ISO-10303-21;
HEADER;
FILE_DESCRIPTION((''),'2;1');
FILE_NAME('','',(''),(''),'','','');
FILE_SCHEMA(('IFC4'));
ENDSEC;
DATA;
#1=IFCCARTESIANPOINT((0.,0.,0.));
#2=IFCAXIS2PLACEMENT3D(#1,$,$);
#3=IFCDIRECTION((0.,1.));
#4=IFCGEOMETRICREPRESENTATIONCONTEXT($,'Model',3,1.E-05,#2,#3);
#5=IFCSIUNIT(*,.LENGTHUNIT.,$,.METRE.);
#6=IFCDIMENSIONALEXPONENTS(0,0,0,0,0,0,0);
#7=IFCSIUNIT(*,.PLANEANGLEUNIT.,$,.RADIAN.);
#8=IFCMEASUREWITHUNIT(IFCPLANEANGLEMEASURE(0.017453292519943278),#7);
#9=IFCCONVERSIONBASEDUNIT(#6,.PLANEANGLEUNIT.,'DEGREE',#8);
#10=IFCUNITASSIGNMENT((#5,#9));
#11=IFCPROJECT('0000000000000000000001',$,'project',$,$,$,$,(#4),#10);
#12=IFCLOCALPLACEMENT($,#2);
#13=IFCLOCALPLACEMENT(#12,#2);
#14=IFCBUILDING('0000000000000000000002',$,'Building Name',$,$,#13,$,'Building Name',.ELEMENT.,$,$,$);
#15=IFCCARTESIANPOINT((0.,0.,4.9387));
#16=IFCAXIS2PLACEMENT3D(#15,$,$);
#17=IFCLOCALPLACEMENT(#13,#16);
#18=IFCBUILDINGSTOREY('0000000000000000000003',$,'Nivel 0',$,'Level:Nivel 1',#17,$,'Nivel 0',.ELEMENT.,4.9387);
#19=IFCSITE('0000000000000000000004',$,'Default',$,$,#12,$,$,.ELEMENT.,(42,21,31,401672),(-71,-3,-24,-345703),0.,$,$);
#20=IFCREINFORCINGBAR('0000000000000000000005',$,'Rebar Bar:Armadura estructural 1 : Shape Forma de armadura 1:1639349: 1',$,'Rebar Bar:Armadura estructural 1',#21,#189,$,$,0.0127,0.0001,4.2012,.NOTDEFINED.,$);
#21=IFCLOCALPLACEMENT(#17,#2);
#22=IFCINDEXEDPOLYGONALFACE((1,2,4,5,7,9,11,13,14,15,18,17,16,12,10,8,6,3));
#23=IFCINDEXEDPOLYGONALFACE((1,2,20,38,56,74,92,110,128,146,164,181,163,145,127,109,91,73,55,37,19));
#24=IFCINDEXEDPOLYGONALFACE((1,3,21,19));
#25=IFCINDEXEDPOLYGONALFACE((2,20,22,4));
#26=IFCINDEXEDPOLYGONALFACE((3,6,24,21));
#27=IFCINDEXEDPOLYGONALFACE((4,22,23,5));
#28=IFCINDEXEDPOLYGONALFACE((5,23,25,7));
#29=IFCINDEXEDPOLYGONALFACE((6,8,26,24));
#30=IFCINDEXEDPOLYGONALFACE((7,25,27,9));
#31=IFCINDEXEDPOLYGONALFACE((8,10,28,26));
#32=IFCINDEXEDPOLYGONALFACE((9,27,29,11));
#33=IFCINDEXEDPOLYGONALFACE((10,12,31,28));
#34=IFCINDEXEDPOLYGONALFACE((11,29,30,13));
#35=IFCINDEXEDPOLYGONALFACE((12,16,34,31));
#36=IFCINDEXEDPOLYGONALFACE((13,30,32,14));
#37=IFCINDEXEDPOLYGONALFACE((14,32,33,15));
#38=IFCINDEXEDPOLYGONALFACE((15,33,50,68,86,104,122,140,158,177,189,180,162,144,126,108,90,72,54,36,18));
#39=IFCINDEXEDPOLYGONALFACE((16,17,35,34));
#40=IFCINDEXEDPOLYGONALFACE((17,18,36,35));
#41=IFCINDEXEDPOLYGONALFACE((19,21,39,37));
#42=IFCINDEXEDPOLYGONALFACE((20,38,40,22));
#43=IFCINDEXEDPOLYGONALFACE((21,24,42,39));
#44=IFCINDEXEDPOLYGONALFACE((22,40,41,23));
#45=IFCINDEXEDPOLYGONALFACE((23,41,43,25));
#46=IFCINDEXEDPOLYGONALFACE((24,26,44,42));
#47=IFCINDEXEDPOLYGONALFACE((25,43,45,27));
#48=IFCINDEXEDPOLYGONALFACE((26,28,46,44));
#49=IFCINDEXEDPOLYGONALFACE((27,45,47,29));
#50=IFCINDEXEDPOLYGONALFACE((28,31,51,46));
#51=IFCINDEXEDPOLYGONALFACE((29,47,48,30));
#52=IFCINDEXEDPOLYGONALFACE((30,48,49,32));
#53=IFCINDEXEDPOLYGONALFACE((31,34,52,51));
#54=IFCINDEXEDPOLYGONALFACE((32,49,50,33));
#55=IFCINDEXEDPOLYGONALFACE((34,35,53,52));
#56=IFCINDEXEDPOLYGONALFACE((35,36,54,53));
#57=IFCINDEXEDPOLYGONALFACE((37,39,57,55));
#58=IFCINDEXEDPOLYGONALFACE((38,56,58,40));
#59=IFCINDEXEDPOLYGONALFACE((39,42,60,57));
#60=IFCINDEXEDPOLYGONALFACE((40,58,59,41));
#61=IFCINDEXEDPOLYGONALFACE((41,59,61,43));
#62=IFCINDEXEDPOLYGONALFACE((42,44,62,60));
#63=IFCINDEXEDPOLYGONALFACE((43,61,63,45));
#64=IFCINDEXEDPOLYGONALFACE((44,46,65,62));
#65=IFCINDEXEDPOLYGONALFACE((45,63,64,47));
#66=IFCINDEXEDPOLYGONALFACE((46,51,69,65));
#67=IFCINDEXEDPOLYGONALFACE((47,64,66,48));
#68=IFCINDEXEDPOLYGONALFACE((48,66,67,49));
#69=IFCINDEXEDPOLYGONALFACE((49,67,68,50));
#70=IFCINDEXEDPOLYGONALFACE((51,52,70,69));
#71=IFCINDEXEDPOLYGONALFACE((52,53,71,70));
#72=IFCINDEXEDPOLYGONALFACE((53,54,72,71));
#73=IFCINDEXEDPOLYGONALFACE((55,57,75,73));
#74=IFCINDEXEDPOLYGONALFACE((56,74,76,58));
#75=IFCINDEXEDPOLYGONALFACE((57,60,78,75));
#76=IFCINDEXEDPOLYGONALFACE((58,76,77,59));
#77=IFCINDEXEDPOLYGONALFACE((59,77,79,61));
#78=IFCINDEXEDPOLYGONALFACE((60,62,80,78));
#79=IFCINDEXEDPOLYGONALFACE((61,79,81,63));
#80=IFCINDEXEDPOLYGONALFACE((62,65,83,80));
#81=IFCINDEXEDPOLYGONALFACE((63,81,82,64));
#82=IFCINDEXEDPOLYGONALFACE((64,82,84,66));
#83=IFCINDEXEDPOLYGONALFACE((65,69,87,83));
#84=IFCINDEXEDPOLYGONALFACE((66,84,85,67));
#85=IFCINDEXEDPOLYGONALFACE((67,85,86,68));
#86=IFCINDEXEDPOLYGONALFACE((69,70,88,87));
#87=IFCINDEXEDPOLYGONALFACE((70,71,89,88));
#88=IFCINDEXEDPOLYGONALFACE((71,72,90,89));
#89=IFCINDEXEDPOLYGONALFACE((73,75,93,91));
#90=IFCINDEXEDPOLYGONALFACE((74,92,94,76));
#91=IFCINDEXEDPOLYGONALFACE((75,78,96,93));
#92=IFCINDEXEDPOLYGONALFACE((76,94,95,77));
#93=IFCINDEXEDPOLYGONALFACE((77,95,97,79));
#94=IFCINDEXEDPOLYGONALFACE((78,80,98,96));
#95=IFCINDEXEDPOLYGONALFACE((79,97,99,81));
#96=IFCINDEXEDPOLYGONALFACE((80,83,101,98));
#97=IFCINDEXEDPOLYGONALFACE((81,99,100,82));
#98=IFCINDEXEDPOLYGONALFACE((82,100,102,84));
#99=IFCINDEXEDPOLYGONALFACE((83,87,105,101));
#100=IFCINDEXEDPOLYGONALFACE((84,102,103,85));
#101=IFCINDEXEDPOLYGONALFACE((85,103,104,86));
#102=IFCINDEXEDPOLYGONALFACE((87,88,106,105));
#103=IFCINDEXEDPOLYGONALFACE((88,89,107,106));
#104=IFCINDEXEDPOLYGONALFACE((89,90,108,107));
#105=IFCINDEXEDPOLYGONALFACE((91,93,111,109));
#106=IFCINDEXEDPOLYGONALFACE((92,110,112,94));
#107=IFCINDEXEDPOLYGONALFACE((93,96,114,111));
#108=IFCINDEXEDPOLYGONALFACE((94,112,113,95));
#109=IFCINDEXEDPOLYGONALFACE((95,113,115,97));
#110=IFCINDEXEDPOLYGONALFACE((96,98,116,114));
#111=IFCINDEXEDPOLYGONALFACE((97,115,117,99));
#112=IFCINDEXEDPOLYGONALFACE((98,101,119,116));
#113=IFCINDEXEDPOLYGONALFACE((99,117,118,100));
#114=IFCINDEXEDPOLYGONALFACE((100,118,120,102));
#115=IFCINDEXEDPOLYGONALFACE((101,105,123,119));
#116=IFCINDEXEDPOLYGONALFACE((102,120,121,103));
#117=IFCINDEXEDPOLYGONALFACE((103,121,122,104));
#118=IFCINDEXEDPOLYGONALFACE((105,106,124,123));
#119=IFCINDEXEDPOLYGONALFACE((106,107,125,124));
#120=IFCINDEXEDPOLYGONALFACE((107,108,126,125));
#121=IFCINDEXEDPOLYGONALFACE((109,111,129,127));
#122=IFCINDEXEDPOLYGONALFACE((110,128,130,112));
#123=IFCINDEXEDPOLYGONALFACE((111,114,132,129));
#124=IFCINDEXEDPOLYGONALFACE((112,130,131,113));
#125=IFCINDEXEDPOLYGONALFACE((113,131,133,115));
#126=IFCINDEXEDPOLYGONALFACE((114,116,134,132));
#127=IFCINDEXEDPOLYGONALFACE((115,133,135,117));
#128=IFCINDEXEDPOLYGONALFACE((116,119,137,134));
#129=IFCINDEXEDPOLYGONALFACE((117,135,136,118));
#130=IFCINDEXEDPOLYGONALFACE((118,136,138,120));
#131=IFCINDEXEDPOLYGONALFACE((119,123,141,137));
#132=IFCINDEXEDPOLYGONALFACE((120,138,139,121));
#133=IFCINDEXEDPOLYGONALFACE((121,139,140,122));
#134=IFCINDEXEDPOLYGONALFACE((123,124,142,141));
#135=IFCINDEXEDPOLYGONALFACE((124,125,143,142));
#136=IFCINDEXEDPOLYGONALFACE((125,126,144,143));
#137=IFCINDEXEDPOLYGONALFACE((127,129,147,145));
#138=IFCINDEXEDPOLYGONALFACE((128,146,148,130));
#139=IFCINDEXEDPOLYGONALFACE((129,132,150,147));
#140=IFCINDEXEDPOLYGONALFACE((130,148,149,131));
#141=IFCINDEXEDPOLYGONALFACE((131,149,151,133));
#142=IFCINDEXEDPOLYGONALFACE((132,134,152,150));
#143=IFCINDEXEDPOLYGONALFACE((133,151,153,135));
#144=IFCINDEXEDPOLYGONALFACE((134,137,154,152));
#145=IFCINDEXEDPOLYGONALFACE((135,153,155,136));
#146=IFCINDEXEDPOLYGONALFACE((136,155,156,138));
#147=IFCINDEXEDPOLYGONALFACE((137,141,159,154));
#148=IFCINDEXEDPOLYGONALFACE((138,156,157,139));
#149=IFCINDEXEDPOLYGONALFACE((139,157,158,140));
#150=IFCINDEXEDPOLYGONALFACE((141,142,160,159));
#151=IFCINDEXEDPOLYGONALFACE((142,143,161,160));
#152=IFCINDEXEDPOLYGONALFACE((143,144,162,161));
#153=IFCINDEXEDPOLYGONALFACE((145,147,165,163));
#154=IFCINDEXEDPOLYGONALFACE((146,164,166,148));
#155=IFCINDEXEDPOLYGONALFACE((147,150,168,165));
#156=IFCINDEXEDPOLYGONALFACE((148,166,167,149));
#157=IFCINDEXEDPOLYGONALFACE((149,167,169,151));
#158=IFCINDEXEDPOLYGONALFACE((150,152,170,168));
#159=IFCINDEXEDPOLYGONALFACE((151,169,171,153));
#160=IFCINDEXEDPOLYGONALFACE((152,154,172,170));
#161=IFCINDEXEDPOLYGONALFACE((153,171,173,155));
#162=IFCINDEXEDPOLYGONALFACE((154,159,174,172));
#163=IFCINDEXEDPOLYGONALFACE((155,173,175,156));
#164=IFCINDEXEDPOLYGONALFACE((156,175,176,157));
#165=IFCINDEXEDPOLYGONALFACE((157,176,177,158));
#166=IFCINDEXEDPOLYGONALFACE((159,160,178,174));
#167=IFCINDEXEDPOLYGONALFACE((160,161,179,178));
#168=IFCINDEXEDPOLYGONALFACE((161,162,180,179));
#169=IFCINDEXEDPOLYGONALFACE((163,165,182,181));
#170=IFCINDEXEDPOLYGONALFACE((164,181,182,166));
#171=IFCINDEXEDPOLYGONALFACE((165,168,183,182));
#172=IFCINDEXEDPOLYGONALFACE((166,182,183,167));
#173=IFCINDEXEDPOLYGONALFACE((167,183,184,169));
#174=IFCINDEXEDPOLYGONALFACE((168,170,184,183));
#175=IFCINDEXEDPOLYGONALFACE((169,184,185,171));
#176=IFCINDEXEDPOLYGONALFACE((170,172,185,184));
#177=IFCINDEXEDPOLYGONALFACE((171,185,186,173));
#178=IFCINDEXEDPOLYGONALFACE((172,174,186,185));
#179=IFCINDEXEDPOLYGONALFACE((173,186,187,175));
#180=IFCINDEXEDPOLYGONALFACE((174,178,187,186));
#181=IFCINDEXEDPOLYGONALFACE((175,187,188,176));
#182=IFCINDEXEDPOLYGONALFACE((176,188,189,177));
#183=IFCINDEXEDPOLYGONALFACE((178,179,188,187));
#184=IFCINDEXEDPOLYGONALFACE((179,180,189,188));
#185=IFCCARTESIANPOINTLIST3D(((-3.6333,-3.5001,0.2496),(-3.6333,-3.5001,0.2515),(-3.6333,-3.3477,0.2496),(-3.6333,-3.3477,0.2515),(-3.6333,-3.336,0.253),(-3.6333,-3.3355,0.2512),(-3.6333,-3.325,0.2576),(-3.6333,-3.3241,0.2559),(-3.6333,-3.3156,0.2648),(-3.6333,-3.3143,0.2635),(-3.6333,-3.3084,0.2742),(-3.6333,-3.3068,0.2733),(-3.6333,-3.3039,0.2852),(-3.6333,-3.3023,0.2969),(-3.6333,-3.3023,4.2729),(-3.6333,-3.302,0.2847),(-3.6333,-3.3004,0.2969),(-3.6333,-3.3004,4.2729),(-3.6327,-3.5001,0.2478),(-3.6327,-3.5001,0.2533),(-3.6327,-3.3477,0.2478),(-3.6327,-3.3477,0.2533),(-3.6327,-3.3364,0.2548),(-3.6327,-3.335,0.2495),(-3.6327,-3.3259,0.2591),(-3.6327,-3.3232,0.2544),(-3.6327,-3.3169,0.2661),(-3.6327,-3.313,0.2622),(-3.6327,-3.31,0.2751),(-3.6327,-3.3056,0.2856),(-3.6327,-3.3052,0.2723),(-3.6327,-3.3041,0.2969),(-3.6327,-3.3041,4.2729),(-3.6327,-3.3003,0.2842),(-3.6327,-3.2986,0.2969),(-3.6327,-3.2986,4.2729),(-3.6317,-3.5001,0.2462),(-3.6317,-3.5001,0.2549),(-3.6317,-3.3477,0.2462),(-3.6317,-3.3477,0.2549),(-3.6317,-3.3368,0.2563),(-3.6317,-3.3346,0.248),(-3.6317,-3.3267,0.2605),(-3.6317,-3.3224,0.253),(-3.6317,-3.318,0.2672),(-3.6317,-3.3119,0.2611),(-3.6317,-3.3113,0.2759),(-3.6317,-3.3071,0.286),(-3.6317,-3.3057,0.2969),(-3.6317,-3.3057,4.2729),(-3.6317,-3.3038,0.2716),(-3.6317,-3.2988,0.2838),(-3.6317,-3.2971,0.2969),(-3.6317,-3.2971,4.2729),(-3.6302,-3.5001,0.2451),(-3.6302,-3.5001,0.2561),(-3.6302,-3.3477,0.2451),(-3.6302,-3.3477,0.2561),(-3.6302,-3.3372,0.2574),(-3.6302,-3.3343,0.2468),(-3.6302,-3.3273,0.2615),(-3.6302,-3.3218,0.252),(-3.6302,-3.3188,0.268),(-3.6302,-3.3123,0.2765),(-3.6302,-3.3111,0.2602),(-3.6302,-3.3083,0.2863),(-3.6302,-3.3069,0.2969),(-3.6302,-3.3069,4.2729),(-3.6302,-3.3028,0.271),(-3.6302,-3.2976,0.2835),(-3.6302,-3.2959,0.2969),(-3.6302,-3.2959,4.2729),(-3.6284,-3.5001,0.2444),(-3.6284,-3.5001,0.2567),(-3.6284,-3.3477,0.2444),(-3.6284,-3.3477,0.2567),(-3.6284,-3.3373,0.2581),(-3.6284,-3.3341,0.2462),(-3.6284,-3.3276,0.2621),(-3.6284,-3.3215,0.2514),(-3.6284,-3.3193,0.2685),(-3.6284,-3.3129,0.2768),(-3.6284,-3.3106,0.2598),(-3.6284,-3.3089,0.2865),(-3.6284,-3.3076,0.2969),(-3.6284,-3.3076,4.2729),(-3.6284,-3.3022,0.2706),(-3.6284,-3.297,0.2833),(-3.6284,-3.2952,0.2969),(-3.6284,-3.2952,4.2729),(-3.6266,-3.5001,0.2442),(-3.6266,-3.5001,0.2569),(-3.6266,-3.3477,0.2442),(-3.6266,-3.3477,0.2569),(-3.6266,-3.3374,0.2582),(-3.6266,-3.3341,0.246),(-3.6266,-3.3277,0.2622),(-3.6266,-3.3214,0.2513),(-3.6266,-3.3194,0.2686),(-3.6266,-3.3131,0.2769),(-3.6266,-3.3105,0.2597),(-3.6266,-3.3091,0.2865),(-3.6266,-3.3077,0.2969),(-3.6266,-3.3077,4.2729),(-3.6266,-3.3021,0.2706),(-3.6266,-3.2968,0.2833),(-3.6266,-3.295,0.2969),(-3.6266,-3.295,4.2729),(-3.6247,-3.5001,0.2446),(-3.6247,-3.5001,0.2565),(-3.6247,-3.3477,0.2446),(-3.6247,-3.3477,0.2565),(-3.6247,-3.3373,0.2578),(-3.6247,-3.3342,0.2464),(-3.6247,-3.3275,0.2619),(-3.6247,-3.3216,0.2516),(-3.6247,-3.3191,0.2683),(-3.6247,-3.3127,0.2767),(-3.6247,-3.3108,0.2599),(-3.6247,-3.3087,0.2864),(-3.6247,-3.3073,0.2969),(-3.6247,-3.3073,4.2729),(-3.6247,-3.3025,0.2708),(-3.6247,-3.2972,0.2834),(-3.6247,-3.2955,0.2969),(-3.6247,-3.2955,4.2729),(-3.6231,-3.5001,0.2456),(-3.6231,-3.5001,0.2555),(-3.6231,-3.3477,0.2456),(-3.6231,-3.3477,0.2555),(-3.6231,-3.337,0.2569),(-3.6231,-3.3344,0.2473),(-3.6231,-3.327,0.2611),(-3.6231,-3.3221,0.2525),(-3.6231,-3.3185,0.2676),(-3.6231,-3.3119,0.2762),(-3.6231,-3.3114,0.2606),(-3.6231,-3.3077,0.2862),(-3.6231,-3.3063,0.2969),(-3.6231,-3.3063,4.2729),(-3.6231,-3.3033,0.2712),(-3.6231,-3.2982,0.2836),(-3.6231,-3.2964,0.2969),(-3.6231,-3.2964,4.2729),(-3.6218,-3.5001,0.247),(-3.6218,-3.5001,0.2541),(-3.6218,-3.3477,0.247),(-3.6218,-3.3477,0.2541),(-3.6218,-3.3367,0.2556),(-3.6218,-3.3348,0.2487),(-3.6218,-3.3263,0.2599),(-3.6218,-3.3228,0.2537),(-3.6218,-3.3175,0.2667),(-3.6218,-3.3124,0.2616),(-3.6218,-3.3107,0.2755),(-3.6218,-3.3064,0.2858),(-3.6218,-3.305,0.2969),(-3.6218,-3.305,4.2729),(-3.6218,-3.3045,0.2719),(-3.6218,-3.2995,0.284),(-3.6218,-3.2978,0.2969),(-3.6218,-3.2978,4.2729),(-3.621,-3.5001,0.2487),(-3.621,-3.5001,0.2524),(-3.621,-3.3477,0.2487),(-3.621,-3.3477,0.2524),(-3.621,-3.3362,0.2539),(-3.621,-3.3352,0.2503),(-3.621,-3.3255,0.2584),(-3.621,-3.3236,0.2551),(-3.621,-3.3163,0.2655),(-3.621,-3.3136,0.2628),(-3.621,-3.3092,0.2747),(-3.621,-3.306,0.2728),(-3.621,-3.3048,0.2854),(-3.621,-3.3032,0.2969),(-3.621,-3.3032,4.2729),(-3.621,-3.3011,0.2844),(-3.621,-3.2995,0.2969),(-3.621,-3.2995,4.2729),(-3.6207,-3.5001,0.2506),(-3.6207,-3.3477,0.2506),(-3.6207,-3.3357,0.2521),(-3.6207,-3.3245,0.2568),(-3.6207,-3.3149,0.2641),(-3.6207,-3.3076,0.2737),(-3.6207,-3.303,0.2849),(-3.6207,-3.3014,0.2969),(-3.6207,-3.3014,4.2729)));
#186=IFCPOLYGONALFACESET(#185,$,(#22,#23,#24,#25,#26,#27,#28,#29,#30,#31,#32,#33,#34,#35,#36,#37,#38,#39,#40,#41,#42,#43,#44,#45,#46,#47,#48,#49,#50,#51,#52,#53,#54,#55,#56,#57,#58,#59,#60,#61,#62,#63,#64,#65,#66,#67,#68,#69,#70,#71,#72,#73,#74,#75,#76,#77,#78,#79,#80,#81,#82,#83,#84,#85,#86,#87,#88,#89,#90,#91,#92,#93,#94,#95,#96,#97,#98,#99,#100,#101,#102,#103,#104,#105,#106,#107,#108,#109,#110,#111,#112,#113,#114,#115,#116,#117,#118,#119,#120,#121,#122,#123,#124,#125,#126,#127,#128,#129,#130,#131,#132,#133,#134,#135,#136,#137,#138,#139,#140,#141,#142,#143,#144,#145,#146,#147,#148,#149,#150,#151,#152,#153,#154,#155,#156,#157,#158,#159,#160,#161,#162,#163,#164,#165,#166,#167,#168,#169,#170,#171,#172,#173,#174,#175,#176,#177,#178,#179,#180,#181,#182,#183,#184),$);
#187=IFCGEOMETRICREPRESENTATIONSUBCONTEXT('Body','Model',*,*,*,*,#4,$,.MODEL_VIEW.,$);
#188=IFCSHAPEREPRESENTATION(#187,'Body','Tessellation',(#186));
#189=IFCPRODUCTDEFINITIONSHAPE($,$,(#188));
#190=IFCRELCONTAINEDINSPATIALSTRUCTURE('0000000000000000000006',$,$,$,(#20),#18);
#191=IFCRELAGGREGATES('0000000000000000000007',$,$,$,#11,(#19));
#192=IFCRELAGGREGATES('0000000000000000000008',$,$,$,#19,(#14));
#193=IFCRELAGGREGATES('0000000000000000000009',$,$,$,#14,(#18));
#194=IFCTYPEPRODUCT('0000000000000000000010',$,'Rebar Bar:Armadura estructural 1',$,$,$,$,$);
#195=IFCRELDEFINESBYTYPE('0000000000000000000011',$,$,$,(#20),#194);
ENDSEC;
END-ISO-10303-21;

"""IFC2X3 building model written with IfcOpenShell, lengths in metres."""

from ifc_helpers import new_model, entity, si_unit, converted_unit, direction, frame, origin, place, context, subcontext, project, spatial, type_object, element, save


model = new_model("IFC2X3")

# Units and contexts
model_context = context("Model", 3, precision=1e-05, world=origin(), true_north=direction((0.0, 1.0)))
body_context = subcontext(model_context, "Body", "Model", "MODEL_VIEW")
ifc_project = project(units=[si_unit("LENGTHUNIT", "METRE"), converted_unit("PLANEANGLEUNIT", "DEGREE", entity("IfcPlaneAngleMeasure", 0.017453292519943278), si_unit("PLANEANGLEUNIT", "RADIAN"), dimensions=[0, 0, 0, 0, 0, 0, 0])], contexts=[model_context])

# Site, building, storey
site_placement = place(None, origin())
site = spatial("IfcSite", under=ifc_project, at=site_placement, Name="Default", CompositionType="ELEMENT", RefLatitude=(42, 21, 31, 401672), RefLongitude=(-71, -3, -24, -345703), RefElevation=0.0)
building_placement = place(site_placement, origin())
building = spatial("IfcBuilding", under=site, at=building_placement, Name="Building Name", LongName="Building Name", CompositionType="ELEMENT")
storey_placement = place(building_placement, frame((0.0, 0.0, 4.9387)))
storey = spatial("IfcBuildingStorey", under=building, at=storey_placement, Name="Nivel 0", ObjectType="Level:Nivel 1", LongName="Nivel 0", CompositionType="ELEMENT", Elevation=4.9387)

# Reinforcing bar
type_product = type_object("IfcTypeProduct", Name="Rebar Bar:Armadura estructural 1")
reinforcing_bar_1_placement = place(storey_placement, origin())
element("IfcReinforcingBar", 1, at=reinforcing_bar_1_placement, inside=storey, type_object=type_product, Name="Rebar Bar:Armadura estructural 1 : Shape Forma de armadura 1:1639349: 1", ObjectType="Rebar Bar:Armadura estructural 1", BarLength=4.2012, BarRole="NOTDEFINED", CrossSectionArea=0.0001, NominalDiameter=0.0127, context=body_context, shape_type="AdvancedSweptSolid", body=[
    entity("IfcSweptDiskSolid", entity("IfcCompositeCurve", [entity("IfcCompositeCurveSegment", "CONTINUOUS", True, entity("IfcPolyline", [entity("IfcCartesianPoint", [-3.627, -3.5001, 0.2506]), entity("IfcCartesianPoint", [-3.627, -3.3477, 0.2506])])), entity("IfcCompositeCurveSegment", "CONTINUOUS", True, entity("IfcTrimmedCurve", entity("IfcCircle", entity("IfcAxis2Placement3D", entity("IfcCartesianPoint", [-3.627, -3.3477, 0.2969]), entity("IfcDirection", [1.0, 0.0, 0.0]), entity("IfcDirection", [0.0, 1.0, 0.0])), 0.0464), [entity("IfcParameterValue", 270.0)], [entity("IfcParameterValue", 360.0)], True, "PARAMETER")), entity("IfcCompositeCurveSegment", "CONTINUOUS", True, entity("IfcPolyline", [entity("IfcCartesianPoint", [-3.627, -3.3014, 0.2969]), entity("IfcCartesianPoint", [-3.627, -3.3014, 4.2729])]))], False), 0.0063, None, 0.0, 92.0),
])

save(model, "model.ifc")
